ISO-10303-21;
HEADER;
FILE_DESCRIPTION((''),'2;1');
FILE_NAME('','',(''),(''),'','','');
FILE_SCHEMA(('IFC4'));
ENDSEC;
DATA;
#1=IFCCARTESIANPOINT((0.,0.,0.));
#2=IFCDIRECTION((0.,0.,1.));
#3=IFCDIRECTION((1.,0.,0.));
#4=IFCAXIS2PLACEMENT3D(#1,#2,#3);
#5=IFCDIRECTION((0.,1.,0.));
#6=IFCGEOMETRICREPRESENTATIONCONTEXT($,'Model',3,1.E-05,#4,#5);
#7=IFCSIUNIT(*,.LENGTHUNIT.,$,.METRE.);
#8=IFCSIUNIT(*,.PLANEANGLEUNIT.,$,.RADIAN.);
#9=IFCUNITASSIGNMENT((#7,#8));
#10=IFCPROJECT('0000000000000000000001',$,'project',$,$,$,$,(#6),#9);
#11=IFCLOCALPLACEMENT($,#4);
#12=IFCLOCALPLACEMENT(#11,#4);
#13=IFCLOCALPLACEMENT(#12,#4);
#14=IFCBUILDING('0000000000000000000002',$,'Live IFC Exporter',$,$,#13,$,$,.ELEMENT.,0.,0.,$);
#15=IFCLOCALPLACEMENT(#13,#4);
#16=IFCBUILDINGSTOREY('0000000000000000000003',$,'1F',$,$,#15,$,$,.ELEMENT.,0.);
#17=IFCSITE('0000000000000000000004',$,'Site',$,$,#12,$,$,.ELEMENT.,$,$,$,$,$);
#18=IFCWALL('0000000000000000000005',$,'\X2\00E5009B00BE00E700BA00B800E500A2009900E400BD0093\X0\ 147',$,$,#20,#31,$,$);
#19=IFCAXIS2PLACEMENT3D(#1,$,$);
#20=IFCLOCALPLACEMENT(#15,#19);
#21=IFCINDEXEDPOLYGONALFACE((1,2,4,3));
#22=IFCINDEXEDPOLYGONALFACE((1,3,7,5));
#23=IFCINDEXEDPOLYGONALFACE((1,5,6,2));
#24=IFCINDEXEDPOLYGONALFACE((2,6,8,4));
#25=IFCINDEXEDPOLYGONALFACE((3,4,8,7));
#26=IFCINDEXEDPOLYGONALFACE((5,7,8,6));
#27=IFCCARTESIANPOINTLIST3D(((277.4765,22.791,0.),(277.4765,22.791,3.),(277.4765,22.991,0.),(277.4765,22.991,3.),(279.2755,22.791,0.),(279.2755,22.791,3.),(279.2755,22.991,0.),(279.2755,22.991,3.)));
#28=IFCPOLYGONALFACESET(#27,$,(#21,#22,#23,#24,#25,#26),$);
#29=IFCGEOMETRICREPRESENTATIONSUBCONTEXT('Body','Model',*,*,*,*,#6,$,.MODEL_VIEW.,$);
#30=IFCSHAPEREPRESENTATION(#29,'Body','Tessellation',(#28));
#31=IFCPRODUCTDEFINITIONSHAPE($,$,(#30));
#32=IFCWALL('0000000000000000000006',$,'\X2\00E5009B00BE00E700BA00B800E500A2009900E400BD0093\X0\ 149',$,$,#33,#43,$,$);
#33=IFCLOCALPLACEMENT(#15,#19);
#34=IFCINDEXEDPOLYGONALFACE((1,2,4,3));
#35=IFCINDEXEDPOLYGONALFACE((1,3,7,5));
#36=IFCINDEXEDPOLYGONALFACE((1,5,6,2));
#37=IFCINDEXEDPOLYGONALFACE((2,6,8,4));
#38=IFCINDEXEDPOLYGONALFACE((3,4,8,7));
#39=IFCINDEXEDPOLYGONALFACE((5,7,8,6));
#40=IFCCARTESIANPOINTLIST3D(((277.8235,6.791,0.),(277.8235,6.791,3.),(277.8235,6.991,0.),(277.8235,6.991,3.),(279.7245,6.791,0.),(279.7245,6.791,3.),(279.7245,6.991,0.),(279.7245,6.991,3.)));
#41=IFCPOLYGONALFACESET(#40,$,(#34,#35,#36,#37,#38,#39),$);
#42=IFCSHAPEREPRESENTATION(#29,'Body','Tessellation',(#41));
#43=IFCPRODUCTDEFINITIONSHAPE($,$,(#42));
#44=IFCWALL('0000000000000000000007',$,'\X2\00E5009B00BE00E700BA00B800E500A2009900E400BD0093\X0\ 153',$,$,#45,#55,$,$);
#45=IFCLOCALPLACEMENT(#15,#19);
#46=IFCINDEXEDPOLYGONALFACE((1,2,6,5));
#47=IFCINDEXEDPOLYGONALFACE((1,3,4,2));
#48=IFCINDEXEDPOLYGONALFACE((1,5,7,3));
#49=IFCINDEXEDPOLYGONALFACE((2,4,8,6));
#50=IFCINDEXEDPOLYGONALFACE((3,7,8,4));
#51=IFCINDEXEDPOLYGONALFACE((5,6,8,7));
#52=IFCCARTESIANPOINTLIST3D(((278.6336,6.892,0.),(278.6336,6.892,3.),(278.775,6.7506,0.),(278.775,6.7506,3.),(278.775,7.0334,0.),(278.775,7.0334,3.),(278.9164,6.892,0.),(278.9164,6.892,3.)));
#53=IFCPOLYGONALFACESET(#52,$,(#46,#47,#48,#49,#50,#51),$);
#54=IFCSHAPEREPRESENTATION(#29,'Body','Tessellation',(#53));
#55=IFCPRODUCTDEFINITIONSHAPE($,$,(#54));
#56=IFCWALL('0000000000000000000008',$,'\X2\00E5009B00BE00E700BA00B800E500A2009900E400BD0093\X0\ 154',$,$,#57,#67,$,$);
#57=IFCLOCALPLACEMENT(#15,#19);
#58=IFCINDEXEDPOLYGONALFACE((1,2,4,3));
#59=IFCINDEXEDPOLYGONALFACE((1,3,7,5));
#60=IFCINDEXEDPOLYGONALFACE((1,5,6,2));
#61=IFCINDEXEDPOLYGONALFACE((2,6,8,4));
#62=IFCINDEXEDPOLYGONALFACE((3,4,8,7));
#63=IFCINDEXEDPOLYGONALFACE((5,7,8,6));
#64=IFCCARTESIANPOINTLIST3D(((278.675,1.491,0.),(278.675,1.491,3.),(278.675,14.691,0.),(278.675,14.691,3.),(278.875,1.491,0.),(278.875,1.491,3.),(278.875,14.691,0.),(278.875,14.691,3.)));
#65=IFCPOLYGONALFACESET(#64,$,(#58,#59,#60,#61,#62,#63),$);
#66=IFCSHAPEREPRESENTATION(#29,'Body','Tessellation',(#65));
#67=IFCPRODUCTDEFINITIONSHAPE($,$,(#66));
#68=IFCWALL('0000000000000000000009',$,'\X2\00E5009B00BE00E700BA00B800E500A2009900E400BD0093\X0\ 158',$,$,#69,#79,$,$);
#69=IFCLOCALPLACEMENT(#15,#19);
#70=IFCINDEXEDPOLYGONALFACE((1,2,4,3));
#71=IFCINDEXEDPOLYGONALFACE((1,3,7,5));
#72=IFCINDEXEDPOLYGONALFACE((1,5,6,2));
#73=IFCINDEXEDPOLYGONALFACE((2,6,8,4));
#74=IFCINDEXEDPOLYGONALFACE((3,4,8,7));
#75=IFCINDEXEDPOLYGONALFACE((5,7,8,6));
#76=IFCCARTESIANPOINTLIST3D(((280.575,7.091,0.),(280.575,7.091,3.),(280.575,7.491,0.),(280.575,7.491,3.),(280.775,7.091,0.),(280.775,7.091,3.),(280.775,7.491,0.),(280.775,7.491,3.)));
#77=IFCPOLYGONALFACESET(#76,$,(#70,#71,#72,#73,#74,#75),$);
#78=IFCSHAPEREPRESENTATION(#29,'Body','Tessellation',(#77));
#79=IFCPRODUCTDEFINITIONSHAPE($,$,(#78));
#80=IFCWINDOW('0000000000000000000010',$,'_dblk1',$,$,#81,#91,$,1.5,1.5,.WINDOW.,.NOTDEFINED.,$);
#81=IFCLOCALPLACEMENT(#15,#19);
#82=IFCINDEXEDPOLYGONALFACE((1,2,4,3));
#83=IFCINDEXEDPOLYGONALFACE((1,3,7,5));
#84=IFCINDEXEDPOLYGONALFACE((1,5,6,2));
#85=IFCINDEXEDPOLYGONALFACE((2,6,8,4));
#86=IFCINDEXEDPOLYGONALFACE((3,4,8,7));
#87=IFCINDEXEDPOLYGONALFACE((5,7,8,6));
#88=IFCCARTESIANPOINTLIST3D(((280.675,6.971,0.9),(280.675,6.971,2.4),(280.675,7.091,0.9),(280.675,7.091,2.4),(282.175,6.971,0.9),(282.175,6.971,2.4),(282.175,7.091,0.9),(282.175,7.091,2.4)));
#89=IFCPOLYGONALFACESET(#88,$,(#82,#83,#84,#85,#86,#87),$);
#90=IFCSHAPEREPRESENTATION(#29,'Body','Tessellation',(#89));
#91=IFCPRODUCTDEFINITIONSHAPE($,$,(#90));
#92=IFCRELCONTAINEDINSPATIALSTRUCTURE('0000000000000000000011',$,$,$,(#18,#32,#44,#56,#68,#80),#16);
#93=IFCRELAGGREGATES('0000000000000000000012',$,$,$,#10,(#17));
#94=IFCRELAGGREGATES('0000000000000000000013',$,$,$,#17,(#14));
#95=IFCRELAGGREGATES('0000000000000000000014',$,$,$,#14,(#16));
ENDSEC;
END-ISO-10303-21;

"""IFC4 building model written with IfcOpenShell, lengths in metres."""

from ifc_helpers import new_model, si_unit, direction, frame, frame_2d, origin_with_axes, place, context, subcontext, project, spatial, rectangle, extrude, element, save


model = new_model("IFC4")

# Units and contexts
model_context = context("Model", 3, precision=1e-05, world=origin_with_axes(), true_north=direction((0.0, 1.0, 0.0)))
body_context = subcontext(model_context, "Body", "Model", "MODEL_VIEW")
ifc_project = project(units=[si_unit("LENGTHUNIT", "METRE"), si_unit("PLANEANGLEUNIT", "RADIAN")], contexts=[model_context])

# Site, building, storey
placement = place(None, origin_with_axes())
site_placement = place(placement, origin_with_axes())
site = spatial("IfcSite", under=ifc_project, at=site_placement, Name="Site", CompositionType="ELEMENT")
building_placement = place(site_placement, origin_with_axes())
building = spatial("IfcBuilding", under=site, at=building_placement, Name="Live IFC Exporter", CompositionType="ELEMENT", ElevationOfRefHeight=0.0, ElevationOfTerrain=0.0)
storey_placement = place(building_placement, origin_with_axes())
storey = spatial("IfcBuildingStorey", under=building, at=storey_placement, Name="1F", CompositionType="ELEMENT", Elevation=0.0)

# Walls
wall_1_placement = place(storey_placement, frame((278.376, 22.891, 0.0), z_axis=(0.0, 0.0, 1.0), x_axis=(1.0, 0.0, 0.0)))
element("IfcWall", 1, at=wall_1_placement, inside=storey, Name="å\u009b¾çº¸å¢\u0099ä½\u0093 147", context=body_context, shape_type="SweptSolid", body=[
    extrude(rectangle(XDim=1.799, YDim=0.2, at=frame_2d((0.0, 0.0), x_axis=(1.0, 0.0, 0.0))), frame((0.0, 0.0, 0.0), z_axis=(0.0, 0.0, 1.0)), (0.0, 0.0, 1.0), 3.0),
])
wall_2_placement = place(storey_placement, frame((278.774, 6.891, 0.0), z_axis=(0.0, 0.0, 1.0), x_axis=(1.0, 0.0, 0.0)))
element("IfcWall", 2, at=wall_2_placement, inside=storey, Name="å\u009b¾çº¸å¢\u0099ä½\u0093 149", context=body_context, shape_type="SweptSolid", body=[
    extrude(rectangle(XDim=1.901, YDim=0.2, at=frame_2d((0.0, 0.0), x_axis=(1.0, 0.0, 0.0))), frame((0.0, 0.0, 0.0), z_axis=(0.0, 0.0, 1.0)), (0.0, 0.0, 1.0), 3.0),
])
wall_3_placement = place(storey_placement, frame((278.775, 6.892, 0.0), z_axis=(0.0, 0.0, 1.0), x_axis=(-0.707107, -0.707107, 0.0)))
element("IfcWall", 3, at=wall_3_placement, inside=storey, Name="å\u009b¾çº¸å¢\u0099ä½\u0093 153", context=body_context, shape_type="SweptSolid", body=[
    extrude(rectangle(XDim=0.2, YDim=0.2, at=frame_2d((0.0, 0.0), x_axis=(1.0, 0.0, 0.0))), frame((0.0, 0.0, 0.0), z_axis=(0.0, 0.0, 1.0)), (0.0, 0.0, 1.0), 3.0),
])
wall_4_placement = place(storey_placement, frame((278.775, 8.091, 0.0), z_axis=(0.0, 0.0, 1.0), x_axis=(0.0, 1.0, 0.0)))
element("IfcWall", 4, at=wall_4_placement, inside=storey, Name="å\u009b¾çº¸å¢\u0099ä½\u0093 154", context=body_context, shape_type="SweptSolid", body=[
    extrude(rectangle(XDim=13.2, YDim=0.2, at=frame_2d((0.0, 0.0), x_axis=(1.0, 0.0, 0.0))), frame((0.0, 0.0, 0.0), z_axis=(0.0, 0.0, 1.0)), (0.0, 0.0, 1.0), 3.0),
])
wall_5_placement = place(storey_placement, frame((280.675, 7.291, 0.0), z_axis=(0.0, 0.0, 1.0), x_axis=(0.0, -1.0, 0.0)))
element("IfcWall", 5, at=wall_5_placement, inside=storey, Name="å\u009b¾çº¸å¢\u0099ä½\u0093 158", context=body_context, shape_type="SweptSolid", body=[
    extrude(rectangle(XDim=0.4, YDim=0.2, at=frame_2d((0.0, 0.0), x_axis=(1.0, 0.0, 0.0))), frame((0.0, 0.0, 0.0), z_axis=(0.0, 0.0, 1.0)), (0.0, 0.0, 1.0), 3.0),
])

# Window
window_placement = place(storey_placement, frame((281.425, 7.031, 0.9), z_axis=(0.0, 0.0, 1.0), x_axis=(1.0, 0.0, 0.0)))
element("IfcWindow", 6, at=window_placement, inside=storey, Name="_dblk1", OverallHeight=1.5, OverallWidth=1.5, PartitioningType="NOTDEFINED", PredefinedType="WINDOW", context=body_context, shape_type="SweptSolid", body=[
    extrude(rectangle(XDim=1.5, YDim=0.12, at=frame_2d((0.0, 0.0), x_axis=(1.0, 0.0, 0.0))), frame((0.0, 0.0, 0.0), z_axis=(0.0, 0.0, 1.0)), (0.0, 0.0, 1.0), 1.5),
])

save(model, "model.ifc")
